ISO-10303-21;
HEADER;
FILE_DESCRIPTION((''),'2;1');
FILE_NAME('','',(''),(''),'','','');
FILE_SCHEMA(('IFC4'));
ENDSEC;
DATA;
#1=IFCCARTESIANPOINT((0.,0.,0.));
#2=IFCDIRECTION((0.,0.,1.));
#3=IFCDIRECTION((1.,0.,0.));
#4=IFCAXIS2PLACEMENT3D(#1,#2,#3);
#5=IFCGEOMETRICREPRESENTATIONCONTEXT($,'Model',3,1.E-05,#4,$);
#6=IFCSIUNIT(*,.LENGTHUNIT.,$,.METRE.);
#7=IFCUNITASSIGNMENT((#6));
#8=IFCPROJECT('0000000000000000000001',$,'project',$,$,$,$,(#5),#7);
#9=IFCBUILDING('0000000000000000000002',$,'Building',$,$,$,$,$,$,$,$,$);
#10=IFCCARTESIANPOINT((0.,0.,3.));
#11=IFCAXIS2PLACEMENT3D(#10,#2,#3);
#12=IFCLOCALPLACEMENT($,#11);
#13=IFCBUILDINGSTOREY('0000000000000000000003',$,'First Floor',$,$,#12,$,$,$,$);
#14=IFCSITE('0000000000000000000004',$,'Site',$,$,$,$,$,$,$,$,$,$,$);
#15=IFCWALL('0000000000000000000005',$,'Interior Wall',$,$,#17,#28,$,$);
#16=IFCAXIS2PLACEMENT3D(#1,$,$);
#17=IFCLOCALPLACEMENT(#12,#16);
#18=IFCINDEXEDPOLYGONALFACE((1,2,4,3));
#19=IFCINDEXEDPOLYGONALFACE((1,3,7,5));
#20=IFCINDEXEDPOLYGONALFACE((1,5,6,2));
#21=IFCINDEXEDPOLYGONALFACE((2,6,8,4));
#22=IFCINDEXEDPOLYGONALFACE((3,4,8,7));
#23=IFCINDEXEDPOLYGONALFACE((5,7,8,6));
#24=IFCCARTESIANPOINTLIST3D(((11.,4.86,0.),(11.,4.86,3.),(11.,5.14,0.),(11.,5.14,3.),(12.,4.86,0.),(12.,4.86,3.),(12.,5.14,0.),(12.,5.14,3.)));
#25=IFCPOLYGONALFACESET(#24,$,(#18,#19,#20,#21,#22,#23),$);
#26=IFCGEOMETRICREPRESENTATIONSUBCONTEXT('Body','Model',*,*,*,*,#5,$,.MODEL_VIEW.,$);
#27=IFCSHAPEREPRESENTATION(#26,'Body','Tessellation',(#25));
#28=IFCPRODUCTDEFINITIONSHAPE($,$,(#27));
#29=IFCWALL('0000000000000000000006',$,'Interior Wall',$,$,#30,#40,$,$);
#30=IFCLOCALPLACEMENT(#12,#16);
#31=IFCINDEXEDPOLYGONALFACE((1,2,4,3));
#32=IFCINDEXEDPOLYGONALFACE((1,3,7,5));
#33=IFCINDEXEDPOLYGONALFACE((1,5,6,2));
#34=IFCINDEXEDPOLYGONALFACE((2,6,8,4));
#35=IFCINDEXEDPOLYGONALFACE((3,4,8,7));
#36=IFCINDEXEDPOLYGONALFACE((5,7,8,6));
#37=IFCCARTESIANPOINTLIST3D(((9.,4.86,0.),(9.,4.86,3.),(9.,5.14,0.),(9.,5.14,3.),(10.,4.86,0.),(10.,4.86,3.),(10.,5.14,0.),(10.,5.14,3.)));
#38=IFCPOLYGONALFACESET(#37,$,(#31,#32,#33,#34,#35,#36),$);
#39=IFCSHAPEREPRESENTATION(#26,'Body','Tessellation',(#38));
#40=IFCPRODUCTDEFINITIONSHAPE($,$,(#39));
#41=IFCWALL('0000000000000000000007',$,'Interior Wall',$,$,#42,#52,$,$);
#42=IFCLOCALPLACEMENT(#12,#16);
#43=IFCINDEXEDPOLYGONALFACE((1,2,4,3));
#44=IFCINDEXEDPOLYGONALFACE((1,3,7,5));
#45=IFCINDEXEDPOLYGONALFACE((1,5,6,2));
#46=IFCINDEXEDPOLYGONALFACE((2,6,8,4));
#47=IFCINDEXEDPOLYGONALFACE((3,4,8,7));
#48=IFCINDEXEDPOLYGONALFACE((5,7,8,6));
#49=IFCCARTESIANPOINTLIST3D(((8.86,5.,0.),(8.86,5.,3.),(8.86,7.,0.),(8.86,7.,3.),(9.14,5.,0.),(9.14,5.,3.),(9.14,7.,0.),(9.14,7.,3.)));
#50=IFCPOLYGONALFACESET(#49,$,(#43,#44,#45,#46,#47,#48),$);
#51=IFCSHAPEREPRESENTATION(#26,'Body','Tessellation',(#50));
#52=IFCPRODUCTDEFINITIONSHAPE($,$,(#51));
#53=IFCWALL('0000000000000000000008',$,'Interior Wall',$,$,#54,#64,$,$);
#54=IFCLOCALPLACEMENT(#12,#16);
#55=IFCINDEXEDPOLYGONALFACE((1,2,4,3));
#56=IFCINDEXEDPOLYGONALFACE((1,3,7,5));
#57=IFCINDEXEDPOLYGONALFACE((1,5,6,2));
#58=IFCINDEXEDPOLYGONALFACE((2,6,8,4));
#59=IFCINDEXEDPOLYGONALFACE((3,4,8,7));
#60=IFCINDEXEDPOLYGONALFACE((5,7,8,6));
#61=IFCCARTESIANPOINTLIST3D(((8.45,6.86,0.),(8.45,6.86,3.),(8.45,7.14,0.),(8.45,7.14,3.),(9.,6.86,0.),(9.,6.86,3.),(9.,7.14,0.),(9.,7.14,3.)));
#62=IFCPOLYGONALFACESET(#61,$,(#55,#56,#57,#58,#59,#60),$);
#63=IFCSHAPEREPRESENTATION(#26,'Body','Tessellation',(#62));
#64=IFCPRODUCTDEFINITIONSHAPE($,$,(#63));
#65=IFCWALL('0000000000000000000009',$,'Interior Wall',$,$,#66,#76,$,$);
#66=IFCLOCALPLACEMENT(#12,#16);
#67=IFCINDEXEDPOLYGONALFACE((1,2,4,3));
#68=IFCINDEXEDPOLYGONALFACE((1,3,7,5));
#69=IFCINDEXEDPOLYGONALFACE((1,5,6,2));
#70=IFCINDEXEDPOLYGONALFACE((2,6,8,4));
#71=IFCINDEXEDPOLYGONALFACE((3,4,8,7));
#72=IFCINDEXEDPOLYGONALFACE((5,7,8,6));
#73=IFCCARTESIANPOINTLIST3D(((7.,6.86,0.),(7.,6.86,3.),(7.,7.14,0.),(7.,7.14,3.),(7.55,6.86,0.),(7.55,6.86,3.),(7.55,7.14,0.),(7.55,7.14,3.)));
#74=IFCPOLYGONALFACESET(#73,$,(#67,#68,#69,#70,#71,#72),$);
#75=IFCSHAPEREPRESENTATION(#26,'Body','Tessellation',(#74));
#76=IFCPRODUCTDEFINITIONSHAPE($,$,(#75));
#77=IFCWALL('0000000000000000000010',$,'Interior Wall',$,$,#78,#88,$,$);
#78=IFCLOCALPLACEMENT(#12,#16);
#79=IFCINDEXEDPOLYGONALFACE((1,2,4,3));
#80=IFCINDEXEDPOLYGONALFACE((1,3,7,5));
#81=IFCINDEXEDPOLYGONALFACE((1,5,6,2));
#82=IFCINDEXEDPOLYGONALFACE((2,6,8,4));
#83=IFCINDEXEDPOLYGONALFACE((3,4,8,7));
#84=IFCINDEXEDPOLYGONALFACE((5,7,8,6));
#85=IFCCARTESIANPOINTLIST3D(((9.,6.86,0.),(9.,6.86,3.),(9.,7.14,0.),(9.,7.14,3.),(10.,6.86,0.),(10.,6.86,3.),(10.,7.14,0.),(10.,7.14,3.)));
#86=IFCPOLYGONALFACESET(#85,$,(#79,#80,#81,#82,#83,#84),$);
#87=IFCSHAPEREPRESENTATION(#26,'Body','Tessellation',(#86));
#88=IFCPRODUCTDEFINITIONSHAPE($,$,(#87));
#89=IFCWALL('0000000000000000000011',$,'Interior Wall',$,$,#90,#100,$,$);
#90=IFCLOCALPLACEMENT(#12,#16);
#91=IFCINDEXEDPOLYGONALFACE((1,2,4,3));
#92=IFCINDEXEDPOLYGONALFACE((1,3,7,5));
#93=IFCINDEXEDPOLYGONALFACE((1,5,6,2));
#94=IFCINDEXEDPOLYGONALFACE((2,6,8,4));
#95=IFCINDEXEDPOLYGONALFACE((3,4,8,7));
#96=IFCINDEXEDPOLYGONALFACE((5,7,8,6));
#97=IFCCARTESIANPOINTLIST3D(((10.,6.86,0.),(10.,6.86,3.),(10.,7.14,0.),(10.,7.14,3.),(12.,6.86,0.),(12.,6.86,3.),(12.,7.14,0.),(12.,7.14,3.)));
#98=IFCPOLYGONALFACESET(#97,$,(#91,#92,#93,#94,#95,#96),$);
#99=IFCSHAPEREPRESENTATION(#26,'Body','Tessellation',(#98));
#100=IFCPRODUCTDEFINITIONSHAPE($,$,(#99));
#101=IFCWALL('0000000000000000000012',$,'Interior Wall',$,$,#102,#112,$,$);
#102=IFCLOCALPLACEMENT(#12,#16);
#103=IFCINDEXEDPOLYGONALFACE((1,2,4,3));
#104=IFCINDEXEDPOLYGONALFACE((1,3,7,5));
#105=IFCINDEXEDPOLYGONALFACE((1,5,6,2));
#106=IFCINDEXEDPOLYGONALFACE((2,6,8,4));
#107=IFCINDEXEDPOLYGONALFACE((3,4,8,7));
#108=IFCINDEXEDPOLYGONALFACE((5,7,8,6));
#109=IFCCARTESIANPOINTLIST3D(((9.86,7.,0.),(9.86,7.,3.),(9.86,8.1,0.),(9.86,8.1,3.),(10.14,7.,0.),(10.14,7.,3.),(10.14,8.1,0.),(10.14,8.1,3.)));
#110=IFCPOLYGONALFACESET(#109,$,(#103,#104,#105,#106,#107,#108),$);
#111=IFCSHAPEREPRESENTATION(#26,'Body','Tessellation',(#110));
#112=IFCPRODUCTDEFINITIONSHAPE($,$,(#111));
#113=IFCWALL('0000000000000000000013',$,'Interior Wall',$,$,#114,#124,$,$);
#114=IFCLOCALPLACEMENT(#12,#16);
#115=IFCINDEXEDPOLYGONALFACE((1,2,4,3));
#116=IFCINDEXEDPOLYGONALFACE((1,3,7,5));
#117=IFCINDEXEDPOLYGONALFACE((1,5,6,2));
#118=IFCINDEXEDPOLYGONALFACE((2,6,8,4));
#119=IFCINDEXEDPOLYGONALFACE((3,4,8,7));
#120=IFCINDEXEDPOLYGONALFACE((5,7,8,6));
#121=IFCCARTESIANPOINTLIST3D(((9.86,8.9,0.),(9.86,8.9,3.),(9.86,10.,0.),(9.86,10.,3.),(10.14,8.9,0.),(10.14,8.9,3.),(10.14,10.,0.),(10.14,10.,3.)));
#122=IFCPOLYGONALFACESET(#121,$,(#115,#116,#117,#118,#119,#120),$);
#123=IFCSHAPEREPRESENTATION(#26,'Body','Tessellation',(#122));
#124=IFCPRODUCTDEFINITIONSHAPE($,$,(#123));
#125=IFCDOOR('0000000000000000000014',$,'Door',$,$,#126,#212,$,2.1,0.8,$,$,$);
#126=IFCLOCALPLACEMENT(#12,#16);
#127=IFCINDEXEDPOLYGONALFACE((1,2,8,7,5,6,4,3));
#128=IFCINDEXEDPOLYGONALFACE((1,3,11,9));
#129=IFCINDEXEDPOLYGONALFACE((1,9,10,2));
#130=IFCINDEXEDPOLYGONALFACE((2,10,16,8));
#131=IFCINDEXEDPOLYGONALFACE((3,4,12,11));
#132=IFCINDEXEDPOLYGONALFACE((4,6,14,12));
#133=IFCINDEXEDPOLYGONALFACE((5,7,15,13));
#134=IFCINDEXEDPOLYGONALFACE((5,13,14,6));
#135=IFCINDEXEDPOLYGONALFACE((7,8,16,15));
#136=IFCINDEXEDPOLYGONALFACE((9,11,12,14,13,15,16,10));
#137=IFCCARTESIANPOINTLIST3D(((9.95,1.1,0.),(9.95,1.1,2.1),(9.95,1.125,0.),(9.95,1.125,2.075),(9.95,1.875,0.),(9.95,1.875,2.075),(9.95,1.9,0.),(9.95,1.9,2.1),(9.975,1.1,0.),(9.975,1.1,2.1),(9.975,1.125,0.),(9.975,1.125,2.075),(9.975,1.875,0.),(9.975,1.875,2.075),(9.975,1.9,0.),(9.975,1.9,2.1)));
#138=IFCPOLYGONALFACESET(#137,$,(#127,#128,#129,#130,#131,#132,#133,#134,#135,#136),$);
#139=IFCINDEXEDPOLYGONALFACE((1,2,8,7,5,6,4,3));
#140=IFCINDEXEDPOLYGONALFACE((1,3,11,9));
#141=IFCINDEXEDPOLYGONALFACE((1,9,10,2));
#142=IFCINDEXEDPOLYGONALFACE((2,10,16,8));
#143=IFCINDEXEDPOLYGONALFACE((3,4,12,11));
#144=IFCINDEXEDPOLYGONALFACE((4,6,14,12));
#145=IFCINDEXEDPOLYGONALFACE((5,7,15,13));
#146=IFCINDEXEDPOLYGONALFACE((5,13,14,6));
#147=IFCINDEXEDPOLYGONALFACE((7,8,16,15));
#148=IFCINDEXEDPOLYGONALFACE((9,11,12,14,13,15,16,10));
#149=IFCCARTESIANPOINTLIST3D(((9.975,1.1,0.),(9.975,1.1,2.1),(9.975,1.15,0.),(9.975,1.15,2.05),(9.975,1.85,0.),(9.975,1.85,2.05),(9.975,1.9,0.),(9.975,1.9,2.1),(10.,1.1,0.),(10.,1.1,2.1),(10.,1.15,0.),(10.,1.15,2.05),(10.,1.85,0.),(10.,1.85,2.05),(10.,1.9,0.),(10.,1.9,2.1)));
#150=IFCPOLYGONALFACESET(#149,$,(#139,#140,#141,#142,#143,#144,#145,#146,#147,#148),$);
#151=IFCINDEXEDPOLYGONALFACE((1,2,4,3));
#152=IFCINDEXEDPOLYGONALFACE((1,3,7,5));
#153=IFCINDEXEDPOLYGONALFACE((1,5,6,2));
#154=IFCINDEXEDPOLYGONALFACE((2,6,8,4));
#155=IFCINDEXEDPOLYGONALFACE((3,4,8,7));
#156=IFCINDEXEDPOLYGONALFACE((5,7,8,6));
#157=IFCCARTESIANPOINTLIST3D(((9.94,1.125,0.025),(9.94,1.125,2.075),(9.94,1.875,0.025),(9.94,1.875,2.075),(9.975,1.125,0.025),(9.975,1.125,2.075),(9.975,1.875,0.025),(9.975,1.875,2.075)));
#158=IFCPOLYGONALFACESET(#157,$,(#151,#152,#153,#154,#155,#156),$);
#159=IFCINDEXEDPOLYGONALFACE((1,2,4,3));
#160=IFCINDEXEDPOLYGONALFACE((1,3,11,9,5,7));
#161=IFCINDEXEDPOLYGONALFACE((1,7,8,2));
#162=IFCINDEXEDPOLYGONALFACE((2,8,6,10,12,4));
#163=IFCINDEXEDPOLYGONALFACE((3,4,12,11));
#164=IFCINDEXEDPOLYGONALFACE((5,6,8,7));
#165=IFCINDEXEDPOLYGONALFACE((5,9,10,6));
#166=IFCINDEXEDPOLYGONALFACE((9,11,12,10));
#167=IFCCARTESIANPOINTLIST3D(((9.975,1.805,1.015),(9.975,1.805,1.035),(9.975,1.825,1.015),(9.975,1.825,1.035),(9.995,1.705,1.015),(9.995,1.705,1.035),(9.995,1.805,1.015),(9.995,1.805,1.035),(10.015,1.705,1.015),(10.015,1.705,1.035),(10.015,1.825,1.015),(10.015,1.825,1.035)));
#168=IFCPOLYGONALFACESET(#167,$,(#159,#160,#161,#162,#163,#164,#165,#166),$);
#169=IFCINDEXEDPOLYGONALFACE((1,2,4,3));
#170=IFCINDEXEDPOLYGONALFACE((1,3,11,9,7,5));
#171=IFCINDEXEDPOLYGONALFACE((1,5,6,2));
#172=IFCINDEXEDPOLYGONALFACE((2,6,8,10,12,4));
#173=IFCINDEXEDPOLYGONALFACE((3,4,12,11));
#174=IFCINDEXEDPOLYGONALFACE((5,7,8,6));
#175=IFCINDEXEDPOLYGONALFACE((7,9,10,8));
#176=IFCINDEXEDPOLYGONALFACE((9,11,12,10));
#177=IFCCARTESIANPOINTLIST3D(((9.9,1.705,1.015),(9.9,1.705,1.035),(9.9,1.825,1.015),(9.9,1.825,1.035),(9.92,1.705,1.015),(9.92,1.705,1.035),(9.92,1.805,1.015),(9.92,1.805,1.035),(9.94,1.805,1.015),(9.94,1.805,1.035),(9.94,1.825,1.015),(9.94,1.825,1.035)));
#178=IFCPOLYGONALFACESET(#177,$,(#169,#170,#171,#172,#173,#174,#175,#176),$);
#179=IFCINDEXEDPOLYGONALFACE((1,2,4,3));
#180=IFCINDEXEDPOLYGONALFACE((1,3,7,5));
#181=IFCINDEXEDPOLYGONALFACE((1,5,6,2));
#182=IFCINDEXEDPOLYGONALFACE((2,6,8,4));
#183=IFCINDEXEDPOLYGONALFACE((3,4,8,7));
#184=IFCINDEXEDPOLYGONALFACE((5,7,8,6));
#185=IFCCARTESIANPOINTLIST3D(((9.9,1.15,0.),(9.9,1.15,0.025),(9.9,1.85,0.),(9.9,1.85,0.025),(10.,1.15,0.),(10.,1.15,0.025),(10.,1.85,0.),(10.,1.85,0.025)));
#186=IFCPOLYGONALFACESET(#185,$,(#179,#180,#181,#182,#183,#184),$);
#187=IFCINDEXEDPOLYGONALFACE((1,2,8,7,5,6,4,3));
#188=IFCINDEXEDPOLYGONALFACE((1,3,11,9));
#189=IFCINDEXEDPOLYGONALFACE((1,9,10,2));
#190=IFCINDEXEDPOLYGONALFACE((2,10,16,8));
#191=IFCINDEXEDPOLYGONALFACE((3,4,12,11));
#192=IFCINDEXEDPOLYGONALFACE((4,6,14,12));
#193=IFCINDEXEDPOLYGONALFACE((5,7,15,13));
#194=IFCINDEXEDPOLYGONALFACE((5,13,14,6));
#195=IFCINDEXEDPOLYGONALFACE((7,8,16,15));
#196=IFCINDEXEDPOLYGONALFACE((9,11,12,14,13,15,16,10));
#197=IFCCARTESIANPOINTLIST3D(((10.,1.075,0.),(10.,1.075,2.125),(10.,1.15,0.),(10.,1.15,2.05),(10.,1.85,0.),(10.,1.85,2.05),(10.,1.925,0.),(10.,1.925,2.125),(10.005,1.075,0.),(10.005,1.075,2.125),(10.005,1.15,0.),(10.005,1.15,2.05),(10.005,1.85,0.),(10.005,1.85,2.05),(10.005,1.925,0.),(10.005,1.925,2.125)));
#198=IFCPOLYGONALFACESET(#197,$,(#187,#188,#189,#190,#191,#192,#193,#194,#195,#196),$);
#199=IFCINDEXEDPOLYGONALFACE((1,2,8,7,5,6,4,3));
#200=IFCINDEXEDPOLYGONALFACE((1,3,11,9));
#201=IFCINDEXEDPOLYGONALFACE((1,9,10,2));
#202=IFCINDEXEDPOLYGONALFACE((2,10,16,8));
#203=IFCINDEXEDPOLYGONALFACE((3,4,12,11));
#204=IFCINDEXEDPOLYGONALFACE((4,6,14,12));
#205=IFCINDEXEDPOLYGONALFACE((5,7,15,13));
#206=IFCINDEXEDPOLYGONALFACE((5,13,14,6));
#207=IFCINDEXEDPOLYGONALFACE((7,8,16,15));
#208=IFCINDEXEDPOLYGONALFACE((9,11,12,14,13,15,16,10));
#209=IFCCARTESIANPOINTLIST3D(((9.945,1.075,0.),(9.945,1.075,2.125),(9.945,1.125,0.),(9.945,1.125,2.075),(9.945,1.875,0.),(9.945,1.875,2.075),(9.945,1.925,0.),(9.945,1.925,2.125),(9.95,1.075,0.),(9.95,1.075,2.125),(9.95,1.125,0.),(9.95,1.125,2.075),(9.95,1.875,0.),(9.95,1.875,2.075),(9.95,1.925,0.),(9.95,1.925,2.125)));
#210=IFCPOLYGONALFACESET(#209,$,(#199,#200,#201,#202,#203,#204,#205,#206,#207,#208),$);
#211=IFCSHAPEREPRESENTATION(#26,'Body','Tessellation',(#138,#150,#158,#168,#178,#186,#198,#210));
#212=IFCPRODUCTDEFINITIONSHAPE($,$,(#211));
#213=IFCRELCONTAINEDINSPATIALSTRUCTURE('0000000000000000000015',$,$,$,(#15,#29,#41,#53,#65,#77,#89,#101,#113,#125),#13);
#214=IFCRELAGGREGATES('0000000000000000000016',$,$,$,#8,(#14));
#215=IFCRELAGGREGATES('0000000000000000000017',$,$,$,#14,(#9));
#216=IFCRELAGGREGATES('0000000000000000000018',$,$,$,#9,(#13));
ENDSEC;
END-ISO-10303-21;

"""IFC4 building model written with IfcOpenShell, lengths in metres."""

from ifc_helpers import new_model, si_unit, frame, origin_with_axes, place, context, subcontext, project, spatial, line, indexed_curve, outline, extrude, element, save


model = new_model("IFC4")

# Units and contexts
model_context = context("Model", 3, precision=1e-05, world=origin_with_axes())
body_context = subcontext(model_context, "Body", "Model", "MODEL_VIEW")
ifc_project = project(units=[si_unit("LENGTHUNIT", "METRE")], contexts=[model_context])

# Site, building, storey
site = spatial("IfcSite", under=ifc_project, Name="Site")
building = spatial("IfcBuilding", under=site, Name="Building")
storey_placement = place(None, frame((0.0, 0.0, 3.0), z_axis=(0.0, 0.0, 1.0), x_axis=(1.0, 0.0, 0.0)))
storey = spatial("IfcBuildingStorey", under=building, at=storey_placement, Name="First Floor")

# Walls
for number, where, z_axis, x_axis, name in (
    (1, (12.0, 5.0, 0.0), (0.0, 0.0, 1.0), (-1.0, 0.0, 0.0), "Interior Wall"),
    (2, (10.0, 5.0, 0.0), (0.0, 0.0, 1.0), (-1.0, 0.0, 0.0), "Interior Wall"),
):
    element("IfcWall", number, at=place(storey_placement, frame(where, z_axis=z_axis, x_axis=x_axis)), inside=storey, Name=name, context=body_context, shape_type="SweptSolid", body=[
        extrude(outline(indexed_curve([(0.0, 0.0), (0.0, 0.28), (1.0, 0.28), (1.0, 0.0), (0.0, 0.0)], self_intersect=False)), frame((0.0, -0.14, 0.0), z_axis=(0.0, 0.0, 1.0), x_axis=(1.0, 0.0, 0.0)), (0.0, 0.0, 1.0), 3.0),
    ])
wall_1_placement = place(storey_placement, frame((9.0, 5.0, 0.0), z_axis=(0.0, 0.0, 1.0), x_axis=(0.0, 1.0, 0.0)))
element("IfcWall", 3, at=wall_1_placement, inside=storey, Name="Interior Wall", context=body_context, shape_type="SweptSolid", body=[
    extrude(outline(indexed_curve([(0.0, 0.0), (0.0, 0.28), (2.0, 0.28), (2.0, 0.0), (0.0, 0.0)], self_intersect=False)), frame((0.0, -0.14, 0.0), z_axis=(0.0, 0.0, 1.0), x_axis=(1.0, 0.0, 0.0)), (0.0, 0.0, 1.0), 3.0),
])
wall_2_placement = place(storey_placement, frame((9.0, 7.0, 0.0), z_axis=(0.0, 0.0, 1.0), x_axis=(-1.0, 0.0, 0.0)))
element("IfcWall", 4, at=wall_2_placement, inside=storey, Name="Interior Wall", context=body_context, shape_type="SweptSolid", body=[
    extrude(outline(indexed_curve([(0.0, 0.0), (0.0, 0.28), (0.55, 0.28), (0.55, 0.0), (0.0, 0.0)], self_intersect=False)), frame((0.0, -0.14, 0.0), z_axis=(0.0, 0.0, 1.0), x_axis=(1.0, 0.0, 0.0)), (0.0, 0.0, 1.0), 3.0),
])
wall_3_placement = place(storey_placement, frame((7.55, 7.0, 0.0), z_axis=(0.0, 0.0, 1.0), x_axis=(-1.0, 0.0, 0.0)))
element("IfcWall", 5, at=wall_3_placement, inside=storey, Name="Interior Wall", context=body_context, shape_type="SweptSolid", body=[
    extrude(outline(indexed_curve([(0.0, 0.0), (0.0, 0.28), (0.55, 0.28), (0.55, 0.0), (0.0, 0.0)], self_intersect=False)), frame((0.0, -0.14, 0.0), z_axis=(0.0, 0.0, 1.0), x_axis=(1.0, 0.0, 0.0)), (0.0, 0.0, 1.0), 3.0),
])
wall_4_placement = place(storey_placement, frame((10.0, 7.0, 0.0), z_axis=(0.0, 0.0, 1.0), x_axis=(-1.0, 0.0, 0.0)))
element("IfcWall", 6, at=wall_4_placement, inside=storey, Name="Interior Wall", context=body_context, shape_type="SweptSolid", body=[
    extrude(outline(indexed_curve([(0.0, 0.0), (0.0, 0.28), (1.0, 0.28), (1.0, 0.0), (0.0, 0.0)], self_intersect=False)), frame((0.0, -0.14, 0.0), z_axis=(0.0, 0.0, 1.0), x_axis=(1.0, 0.0, 0.0)), (0.0, 0.0, 1.0), 3.0),
])
wall_5_placement = place(storey_placement, frame((12.0, 7.0, 0.0), z_axis=(0.0, 0.0, 1.0), x_axis=(-1.0, 0.0, 0.0)))
element("IfcWall", 7, at=wall_5_placement, inside=storey, Name="Interior Wall", context=body_context, shape_type="SweptSolid", body=[
    extrude(outline(indexed_curve([(0.0, 0.0), (0.0, 0.28), (2.0, 0.28), (2.0, 0.0), (0.0, 0.0)], self_intersect=False)), frame((0.0, -0.14, 0.0), z_axis=(0.0, 0.0, 1.0), x_axis=(1.0, 0.0, 0.0)), (0.0, 0.0, 1.0), 3.0),
])
for number, where, z_axis, x_axis, name in (
    (8, (10.0, 7.0, 0.0), (0.0, 0.0, 1.0), (0.0, 1.0, 0.0), "Interior Wall"),
    (9, (10.0, 8.9, 0.0), (0.0, 0.0, 1.0), (0.0, 1.0, 0.0), "Interior Wall"),
):
    element("IfcWall", number, at=place(storey_placement, frame(where, z_axis=z_axis, x_axis=x_axis)), inside=storey, Name=name, context=body_context, shape_type="SweptSolid", body=[
        extrude(outline(indexed_curve([(0.0, 0.0), (0.0, 0.28), (1.1, 0.28), (1.1, 0.0), (0.0, 0.0)], self_intersect=False)), frame((0.0, -0.14, 0.0), z_axis=(0.0, 0.0, 1.0), x_axis=(1.0, 0.0, 0.0)), (0.0, 0.0, 1.0), 3.0),
    ])

# Door
door_1_placement = place(storey_placement, frame((10.0, 1.1, 0.0), z_axis=(0.0, 0.0, 1.0), x_axis=(0.0, 1.0, 0.0)))
element("IfcDoor", 10, at=door_1_placement, inside=storey, Name="Door", OverallHeight=2.1, OverallWidth=0.8, context=body_context, shape_type="SweptSolid", body=[
    extrude(outline(indexed_curve([(0.0, 0.0), (0.0, 2.1), (0.8, 2.1), (0.8, 0.0), (0.775, 0.0), (0.775, 2.075), (0.025, 2.075), (0.025, 0.0)], segments=[line(1, 2, 3, 4, 5, 6, 7, 8, 1)])), frame((0.0, 0.025, 0.0), z_axis=(0.0, -1.0, 0.0), x_axis=(1.0, 0.0, 0.0)), (0.0, 0.0, -1.0), 0.025),
    extrude(outline(indexed_curve([(0.0, 0.0), (0.0, 2.1), (0.8, 2.1), (0.8, 0.0), (0.75, 0.0), (0.75, 2.05), (0.05, 2.05), (0.05, 0.0)], segments=[line(1, 2, 3, 4, 5, 6, 7, 8, 1)])), frame((0.0, 0.0, 0.0), z_axis=(0.0, -1.0, 0.0), x_axis=(1.0, 0.0, 0.0)), (0.0, 0.0, -1.0), 0.025),
    extrude(outline(indexed_curve([(0.0, 0.0), (0.75, 0.0), (0.75, 0.035), (0.0, 0.035)], segments=[line(1, 2, 3, 4, 1)])), frame((0.025, 0.025, 0.025), z_axis=(0.0, 0.0, 1.0), x_axis=(1.0, 0.0, 0.0)), (0.0, 0.0, 1.0), 2.05),
    extrude(outline(indexed_curve([(0.0, 0.0), (0.0, -0.04), (-0.12, -0.04), (-0.12, -0.02), (-0.02, -0.02), (-0.02, 0.0)], segments=[line(1, 2, 3, 4, 5, 6, 1)])), frame((0.725, 0.025, 1.015), z_axis=(0.0, 0.0, 1.0), x_axis=(1.0, 0.0, 0.0)), (0.0, 0.0, 1.0), 0.02),
    extrude(outline(indexed_curve([(0.0, 0.0), (0.0, 0.04), (-0.12, 0.04), (-0.12, 0.02), (-0.02, 0.02), (-0.02, 0.0)], segments=[line(1, 2, 3, 4, 5, 6, 1)])), frame((0.725, 0.06, 1.015), z_axis=(0.0, 0.0, 1.0), x_axis=(1.0, 0.0, 0.0)), (0.0, 0.0, 1.0), 0.02),
    extrude(outline(indexed_curve([(0.0, 0.0), (0.7, 0.0), (0.7, 0.1), (0.0, 0.1)], segments=[line(1, 2, 3, 4, 1)])), frame((0.05, 0.0, 0.0), z_axis=(0.0, 0.0, 1.0), x_axis=(1.0, 0.0, 0.0)), (0.0, 0.0, 1.0), 0.025),
    extrude(outline(indexed_curve([(0.0, 0.0), (0.0, 2.125), (0.85, 2.125), (0.85, 0.0), (0.775, 0.0), (0.775, 2.05), (0.075, 2.05), (0.075, 0.0)], segments=[line(1, 2, 3, 4, 5, 6, 7, 8, 1)])), frame((-0.025, -0.005, 0.0), z_axis=(0.0, -1.0, 0.0), x_axis=(1.0, 0.0, 0.0)), (0.0, 0.0, -1.0), 0.005),
    extrude(outline(indexed_curve([(0.0, 0.0), (0.0, 2.125), (0.85, 2.125), (0.85, 0.0), (0.8, 0.0), (0.8, 2.075), (0.05, 2.075), (0.05, 0.0)], segments=[line(1, 2, 3, 4, 5, 6, 7, 8, 1)])), frame((-0.025, 0.05, 0.0), z_axis=(0.0, -1.0, 0.0), x_axis=(1.0, 0.0, 0.0)), (0.0, 0.0, -1.0), 0.005),
])

save(model, "model.ifc")
